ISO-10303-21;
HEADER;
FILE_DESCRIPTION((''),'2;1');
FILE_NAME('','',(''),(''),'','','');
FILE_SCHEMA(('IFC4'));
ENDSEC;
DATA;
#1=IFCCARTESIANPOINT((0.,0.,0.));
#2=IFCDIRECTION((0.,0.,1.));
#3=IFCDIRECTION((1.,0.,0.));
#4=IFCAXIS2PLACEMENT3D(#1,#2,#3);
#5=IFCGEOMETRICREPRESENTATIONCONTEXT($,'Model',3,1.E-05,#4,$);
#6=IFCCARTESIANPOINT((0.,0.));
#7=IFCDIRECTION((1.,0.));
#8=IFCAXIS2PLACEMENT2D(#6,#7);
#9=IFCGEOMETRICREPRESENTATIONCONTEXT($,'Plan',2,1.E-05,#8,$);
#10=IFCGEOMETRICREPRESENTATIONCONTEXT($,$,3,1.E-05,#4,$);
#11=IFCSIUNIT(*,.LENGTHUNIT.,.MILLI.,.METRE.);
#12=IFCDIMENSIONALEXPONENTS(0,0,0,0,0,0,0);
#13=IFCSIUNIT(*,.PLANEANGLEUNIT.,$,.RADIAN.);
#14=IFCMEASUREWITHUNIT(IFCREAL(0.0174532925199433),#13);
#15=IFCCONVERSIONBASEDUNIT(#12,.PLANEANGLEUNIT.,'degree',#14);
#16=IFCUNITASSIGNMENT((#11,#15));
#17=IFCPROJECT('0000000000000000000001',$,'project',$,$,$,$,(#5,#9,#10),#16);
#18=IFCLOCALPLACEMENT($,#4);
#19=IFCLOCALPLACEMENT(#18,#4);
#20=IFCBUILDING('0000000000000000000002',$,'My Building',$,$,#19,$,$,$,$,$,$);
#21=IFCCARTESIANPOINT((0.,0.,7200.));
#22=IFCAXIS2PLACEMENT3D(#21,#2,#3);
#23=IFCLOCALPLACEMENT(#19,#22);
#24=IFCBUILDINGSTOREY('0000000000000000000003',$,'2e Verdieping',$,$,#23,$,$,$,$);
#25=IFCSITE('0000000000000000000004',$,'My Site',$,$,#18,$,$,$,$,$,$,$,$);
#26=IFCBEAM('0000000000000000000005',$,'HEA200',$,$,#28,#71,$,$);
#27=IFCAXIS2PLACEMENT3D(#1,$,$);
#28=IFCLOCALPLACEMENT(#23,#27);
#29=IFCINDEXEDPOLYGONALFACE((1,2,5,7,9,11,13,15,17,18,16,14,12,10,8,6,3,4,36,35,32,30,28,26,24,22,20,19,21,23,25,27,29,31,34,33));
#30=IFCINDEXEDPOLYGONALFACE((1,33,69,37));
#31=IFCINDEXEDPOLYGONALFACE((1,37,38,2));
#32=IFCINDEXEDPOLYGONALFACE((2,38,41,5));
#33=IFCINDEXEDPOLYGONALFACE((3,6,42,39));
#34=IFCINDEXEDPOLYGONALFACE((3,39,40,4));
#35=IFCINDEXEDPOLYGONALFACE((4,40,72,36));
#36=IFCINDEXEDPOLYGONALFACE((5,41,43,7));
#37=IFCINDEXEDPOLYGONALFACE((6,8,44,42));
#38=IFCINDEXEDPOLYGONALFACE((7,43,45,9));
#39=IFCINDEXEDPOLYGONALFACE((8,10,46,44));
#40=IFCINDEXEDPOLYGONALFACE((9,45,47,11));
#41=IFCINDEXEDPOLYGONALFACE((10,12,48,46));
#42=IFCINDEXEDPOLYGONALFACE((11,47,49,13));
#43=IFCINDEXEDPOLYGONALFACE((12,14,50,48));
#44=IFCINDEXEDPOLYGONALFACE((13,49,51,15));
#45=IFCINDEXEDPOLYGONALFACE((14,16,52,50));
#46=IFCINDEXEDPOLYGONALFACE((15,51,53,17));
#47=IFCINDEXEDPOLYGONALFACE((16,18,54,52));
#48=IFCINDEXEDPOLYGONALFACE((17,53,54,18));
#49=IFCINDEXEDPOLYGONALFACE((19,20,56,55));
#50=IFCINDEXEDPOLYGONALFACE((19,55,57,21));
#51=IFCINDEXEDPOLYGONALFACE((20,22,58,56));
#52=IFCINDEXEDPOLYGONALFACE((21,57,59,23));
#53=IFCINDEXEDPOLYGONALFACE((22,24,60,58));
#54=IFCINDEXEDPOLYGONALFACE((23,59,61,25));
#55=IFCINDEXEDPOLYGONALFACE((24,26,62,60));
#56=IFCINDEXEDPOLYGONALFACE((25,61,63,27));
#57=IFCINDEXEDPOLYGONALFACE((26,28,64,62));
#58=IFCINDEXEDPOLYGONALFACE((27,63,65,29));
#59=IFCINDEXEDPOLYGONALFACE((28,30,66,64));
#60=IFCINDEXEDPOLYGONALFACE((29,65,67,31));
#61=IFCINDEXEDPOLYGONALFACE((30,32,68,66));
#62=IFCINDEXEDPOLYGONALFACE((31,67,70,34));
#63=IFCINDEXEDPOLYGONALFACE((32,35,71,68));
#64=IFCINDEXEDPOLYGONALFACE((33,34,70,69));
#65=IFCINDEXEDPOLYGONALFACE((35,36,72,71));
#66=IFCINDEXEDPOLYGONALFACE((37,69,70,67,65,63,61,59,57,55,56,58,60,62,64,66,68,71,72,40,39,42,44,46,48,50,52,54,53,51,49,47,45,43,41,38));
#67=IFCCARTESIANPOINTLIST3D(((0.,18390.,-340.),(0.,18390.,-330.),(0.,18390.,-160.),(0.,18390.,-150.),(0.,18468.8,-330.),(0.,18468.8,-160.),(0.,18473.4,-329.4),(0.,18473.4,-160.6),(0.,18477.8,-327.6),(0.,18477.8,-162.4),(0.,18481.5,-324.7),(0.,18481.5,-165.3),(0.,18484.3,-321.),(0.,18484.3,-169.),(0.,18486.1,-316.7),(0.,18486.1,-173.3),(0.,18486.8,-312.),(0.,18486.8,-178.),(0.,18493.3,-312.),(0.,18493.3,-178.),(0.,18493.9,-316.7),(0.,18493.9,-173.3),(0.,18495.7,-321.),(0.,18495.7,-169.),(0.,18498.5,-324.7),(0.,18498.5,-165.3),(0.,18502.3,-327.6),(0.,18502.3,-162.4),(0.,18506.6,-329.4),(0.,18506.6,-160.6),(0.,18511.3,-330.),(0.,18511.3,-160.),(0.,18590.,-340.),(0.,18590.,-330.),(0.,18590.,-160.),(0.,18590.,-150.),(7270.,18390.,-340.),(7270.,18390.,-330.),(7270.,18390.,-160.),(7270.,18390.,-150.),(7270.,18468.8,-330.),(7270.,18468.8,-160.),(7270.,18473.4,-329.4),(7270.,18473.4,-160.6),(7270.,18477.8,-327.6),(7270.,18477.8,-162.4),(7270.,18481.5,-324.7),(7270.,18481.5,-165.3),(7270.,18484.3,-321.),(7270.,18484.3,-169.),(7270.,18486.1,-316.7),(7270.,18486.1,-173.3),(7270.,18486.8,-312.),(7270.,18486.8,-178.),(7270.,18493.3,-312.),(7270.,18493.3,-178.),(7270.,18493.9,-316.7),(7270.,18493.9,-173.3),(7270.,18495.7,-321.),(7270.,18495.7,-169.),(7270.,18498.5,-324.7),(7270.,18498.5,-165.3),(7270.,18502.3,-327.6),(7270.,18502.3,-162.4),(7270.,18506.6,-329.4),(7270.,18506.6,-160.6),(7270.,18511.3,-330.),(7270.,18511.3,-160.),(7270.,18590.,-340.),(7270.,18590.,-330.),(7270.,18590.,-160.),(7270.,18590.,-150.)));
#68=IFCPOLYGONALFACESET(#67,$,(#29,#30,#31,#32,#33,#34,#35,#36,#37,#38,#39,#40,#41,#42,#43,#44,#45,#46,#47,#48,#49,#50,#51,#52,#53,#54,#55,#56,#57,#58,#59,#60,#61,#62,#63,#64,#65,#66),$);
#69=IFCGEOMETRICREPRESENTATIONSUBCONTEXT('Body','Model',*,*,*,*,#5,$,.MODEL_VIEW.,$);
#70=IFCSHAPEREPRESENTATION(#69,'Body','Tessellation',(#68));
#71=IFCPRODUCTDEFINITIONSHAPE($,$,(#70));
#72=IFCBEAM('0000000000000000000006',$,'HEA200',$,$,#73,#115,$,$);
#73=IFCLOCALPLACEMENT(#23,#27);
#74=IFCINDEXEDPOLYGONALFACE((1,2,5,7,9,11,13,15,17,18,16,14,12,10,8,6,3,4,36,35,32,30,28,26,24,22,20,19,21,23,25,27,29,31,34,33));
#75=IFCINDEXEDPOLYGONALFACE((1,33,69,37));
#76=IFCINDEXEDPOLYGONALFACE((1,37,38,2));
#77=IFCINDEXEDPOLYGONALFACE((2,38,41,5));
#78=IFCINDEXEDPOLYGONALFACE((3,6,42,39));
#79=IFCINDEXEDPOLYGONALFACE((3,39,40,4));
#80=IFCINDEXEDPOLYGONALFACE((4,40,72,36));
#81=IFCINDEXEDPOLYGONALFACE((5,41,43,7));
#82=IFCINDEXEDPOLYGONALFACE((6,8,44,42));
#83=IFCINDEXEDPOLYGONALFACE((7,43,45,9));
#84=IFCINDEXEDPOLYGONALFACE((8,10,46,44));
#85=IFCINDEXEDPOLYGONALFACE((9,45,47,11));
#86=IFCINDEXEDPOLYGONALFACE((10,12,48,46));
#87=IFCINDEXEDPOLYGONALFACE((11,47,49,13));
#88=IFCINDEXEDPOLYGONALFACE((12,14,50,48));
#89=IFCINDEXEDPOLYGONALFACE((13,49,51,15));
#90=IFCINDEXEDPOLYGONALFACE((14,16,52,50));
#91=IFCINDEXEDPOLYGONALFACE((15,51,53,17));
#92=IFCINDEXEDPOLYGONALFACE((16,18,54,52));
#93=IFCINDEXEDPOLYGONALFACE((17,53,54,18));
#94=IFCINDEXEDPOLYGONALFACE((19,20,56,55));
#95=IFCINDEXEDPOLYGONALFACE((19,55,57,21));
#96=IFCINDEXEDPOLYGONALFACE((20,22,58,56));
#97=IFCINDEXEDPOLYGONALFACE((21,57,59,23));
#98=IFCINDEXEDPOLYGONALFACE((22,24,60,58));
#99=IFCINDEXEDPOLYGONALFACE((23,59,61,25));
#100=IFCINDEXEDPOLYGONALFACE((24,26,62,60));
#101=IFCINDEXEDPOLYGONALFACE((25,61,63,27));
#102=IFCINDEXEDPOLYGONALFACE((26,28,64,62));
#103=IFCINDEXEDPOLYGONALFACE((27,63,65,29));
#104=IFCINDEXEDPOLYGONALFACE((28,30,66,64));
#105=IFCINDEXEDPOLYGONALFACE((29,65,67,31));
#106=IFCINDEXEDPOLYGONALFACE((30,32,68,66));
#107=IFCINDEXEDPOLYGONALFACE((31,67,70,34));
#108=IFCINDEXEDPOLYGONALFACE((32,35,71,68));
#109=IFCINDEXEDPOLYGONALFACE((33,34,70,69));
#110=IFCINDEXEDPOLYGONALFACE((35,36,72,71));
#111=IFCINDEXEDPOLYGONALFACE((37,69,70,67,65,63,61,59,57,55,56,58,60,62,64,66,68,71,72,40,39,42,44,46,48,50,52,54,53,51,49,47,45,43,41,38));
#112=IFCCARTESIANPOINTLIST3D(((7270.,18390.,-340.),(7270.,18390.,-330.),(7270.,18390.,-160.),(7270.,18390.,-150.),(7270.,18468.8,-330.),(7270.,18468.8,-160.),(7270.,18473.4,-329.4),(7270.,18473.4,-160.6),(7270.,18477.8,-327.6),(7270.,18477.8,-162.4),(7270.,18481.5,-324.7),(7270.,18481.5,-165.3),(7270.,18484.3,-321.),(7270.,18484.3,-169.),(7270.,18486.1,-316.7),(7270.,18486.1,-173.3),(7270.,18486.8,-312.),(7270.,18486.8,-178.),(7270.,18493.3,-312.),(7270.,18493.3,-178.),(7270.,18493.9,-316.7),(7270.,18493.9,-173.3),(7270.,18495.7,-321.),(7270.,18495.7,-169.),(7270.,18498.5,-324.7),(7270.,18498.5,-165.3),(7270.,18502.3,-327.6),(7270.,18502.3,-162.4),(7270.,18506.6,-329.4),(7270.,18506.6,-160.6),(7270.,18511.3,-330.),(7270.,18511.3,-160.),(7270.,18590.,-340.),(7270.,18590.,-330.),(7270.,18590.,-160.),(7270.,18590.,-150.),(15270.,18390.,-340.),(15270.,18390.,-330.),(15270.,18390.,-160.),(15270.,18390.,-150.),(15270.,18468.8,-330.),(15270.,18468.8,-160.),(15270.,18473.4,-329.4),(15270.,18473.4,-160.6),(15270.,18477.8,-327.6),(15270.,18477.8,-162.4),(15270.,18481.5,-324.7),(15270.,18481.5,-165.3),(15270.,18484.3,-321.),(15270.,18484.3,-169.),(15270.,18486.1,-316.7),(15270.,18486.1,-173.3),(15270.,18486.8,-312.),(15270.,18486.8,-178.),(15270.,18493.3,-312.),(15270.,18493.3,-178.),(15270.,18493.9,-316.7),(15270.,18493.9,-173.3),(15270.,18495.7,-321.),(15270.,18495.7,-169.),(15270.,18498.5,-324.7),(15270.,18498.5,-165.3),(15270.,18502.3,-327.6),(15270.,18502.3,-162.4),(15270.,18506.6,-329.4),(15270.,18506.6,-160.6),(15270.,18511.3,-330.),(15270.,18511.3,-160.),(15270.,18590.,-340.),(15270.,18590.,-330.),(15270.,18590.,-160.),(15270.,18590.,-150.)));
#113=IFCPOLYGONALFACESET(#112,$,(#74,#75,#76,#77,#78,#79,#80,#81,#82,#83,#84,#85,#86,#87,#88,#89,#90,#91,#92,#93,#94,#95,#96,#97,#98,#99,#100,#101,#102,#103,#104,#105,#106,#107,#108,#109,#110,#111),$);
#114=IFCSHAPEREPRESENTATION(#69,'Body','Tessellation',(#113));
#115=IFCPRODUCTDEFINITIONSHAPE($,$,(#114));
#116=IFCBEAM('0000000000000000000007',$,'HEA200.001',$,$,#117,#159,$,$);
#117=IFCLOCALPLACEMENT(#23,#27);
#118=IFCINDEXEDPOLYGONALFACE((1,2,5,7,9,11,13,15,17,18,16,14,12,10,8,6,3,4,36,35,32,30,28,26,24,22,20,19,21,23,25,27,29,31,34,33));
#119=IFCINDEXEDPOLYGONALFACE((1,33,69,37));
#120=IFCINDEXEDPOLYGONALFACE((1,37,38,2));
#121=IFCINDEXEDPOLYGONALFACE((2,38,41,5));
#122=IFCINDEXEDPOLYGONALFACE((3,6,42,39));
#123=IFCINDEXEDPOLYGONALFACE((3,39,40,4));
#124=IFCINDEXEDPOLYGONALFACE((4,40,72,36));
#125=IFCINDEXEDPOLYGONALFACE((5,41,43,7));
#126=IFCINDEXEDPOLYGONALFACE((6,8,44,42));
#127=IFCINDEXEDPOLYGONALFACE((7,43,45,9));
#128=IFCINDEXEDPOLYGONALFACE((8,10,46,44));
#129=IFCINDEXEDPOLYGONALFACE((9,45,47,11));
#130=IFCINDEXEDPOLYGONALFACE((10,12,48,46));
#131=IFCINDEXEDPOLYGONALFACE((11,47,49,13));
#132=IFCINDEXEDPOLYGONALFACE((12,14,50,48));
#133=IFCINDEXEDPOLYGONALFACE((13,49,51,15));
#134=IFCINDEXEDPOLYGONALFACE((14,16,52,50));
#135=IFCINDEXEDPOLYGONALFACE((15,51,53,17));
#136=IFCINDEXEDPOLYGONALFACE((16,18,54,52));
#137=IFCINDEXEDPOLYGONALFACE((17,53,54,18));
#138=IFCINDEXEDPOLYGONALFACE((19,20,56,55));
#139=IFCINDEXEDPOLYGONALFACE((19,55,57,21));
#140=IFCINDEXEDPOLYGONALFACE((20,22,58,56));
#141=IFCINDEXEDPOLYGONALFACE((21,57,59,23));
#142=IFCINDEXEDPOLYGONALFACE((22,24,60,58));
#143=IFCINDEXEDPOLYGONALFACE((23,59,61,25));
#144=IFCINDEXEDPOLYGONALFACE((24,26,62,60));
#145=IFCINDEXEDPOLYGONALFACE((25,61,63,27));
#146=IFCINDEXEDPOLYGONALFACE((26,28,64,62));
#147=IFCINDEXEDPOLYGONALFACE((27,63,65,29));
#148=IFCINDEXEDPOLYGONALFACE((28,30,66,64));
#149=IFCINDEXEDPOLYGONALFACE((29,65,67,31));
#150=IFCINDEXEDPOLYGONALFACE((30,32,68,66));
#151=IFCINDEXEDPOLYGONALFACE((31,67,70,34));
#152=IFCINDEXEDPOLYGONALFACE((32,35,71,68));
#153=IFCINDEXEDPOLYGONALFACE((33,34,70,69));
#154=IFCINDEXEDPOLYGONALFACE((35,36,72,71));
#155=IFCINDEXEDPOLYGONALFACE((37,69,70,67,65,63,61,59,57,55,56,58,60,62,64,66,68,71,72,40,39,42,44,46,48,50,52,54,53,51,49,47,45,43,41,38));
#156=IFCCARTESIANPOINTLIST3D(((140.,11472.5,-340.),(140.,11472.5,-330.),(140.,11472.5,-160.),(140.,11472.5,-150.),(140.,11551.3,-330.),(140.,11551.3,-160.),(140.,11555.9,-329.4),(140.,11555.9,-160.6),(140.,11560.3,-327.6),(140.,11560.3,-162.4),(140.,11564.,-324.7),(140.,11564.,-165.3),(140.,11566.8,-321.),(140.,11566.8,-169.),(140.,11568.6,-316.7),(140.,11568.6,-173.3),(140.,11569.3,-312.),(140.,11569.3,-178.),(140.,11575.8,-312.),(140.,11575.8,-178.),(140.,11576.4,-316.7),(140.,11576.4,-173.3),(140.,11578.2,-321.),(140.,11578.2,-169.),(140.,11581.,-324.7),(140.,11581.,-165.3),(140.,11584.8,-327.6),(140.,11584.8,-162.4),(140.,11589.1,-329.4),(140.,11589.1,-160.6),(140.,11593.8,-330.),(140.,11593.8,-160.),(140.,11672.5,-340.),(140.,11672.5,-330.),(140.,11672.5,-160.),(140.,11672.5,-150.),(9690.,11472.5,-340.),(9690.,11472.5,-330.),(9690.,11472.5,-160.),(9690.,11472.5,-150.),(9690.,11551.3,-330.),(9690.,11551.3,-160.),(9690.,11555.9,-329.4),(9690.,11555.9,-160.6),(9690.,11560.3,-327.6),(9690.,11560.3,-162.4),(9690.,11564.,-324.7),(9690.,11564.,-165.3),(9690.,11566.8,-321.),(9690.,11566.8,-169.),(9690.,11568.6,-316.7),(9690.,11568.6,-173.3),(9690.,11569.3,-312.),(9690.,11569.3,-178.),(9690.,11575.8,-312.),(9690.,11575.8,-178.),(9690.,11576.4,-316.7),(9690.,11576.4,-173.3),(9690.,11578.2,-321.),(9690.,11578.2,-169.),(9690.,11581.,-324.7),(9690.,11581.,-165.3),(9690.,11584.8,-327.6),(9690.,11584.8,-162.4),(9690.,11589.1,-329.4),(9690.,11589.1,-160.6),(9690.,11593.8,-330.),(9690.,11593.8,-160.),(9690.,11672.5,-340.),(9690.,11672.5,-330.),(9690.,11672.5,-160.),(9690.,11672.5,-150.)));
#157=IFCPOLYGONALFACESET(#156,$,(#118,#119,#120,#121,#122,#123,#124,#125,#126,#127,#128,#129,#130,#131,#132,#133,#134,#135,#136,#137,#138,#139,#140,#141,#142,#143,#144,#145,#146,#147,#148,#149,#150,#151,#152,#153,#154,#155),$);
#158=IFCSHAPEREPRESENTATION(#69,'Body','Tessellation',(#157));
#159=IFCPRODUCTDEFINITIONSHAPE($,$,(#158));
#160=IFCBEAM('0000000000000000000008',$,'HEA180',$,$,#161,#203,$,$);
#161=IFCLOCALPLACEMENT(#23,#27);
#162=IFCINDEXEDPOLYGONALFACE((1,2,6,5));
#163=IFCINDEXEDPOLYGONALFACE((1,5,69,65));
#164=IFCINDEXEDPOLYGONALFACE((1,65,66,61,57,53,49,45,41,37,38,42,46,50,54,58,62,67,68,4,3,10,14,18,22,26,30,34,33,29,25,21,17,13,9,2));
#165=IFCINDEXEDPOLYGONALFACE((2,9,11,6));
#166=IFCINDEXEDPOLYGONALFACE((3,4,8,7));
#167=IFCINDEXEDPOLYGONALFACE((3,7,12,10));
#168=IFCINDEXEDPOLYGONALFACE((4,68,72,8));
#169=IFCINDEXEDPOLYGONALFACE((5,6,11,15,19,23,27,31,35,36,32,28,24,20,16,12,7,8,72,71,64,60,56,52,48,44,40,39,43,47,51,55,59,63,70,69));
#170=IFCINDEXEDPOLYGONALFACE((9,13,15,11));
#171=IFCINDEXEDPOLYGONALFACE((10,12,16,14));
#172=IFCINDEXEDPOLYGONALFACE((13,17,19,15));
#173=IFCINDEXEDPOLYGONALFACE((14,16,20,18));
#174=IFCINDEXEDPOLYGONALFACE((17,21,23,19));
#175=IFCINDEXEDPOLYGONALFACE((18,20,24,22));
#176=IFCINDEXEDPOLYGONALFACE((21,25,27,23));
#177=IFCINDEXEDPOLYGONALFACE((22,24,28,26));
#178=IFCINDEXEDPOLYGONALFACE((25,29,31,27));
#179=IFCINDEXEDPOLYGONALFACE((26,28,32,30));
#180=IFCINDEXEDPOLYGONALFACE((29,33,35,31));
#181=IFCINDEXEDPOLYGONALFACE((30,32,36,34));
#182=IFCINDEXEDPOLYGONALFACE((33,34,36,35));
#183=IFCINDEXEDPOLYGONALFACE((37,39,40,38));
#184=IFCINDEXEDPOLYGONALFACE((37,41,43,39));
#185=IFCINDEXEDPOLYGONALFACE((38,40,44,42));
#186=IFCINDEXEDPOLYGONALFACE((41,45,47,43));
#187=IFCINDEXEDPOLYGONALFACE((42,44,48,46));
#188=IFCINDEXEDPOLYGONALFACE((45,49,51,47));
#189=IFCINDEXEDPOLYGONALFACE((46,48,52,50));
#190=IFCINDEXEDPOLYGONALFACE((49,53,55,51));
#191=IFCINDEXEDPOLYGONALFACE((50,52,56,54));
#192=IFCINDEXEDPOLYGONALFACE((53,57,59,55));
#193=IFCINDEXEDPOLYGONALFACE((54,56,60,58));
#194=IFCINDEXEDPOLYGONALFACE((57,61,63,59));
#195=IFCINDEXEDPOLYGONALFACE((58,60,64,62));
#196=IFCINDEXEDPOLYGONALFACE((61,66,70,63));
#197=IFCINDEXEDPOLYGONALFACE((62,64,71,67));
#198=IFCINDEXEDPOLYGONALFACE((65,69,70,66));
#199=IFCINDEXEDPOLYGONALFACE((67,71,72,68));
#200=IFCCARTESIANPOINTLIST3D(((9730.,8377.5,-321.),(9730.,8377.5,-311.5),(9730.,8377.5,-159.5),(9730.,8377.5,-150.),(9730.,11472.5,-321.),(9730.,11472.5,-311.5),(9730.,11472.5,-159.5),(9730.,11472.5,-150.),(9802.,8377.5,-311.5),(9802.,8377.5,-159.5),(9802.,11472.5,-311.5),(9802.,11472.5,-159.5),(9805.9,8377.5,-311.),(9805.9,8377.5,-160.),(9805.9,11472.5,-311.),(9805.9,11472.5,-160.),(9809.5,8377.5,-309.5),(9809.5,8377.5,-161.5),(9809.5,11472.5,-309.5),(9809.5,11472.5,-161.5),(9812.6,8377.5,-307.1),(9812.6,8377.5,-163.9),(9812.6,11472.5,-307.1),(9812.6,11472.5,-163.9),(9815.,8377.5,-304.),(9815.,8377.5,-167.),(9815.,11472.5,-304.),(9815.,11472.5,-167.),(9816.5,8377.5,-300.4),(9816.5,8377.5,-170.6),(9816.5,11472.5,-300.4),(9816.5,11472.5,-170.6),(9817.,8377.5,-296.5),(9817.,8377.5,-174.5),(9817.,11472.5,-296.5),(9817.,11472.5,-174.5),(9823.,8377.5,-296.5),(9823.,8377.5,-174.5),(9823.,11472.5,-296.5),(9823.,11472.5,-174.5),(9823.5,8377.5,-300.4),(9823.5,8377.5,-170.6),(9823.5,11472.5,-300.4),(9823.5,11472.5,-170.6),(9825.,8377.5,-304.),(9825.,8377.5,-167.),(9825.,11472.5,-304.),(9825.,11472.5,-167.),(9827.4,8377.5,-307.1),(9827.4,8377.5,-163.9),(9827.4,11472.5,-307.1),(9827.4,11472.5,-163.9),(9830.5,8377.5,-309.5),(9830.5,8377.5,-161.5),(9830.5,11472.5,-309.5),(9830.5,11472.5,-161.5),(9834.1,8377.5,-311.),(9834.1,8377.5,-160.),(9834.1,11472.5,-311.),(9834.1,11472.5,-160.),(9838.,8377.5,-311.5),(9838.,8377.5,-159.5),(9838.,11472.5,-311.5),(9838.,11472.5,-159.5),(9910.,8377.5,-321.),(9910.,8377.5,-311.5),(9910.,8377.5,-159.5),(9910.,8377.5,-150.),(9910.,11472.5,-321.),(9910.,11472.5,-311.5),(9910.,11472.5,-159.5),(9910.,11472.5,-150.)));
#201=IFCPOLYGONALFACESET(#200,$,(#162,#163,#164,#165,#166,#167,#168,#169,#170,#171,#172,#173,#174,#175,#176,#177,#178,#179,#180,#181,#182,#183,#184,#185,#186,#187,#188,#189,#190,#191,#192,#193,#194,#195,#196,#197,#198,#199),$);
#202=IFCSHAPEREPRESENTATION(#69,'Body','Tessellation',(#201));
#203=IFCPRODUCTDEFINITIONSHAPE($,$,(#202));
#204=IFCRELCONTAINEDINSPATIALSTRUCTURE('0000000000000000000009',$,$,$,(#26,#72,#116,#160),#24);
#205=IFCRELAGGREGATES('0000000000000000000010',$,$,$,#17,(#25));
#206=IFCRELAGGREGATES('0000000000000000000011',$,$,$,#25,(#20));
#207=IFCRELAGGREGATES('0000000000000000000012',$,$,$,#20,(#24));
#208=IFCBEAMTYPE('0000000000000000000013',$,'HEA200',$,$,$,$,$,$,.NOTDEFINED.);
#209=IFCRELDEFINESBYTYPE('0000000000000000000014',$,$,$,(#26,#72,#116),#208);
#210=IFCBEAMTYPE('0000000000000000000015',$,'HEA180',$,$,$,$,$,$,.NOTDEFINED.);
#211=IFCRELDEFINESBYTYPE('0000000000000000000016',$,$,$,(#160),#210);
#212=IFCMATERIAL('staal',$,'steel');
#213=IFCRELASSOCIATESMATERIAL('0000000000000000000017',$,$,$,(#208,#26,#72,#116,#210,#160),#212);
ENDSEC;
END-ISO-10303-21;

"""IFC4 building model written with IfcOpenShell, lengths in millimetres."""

from ifc_helpers import new_model, entity, si_unit, converted_unit, frame, origin_with_axes, origin_2d_with_axis, place, context, subcontext, project, spatial, i_section, extrude, material, material_profile, profile_set, profile_usage, type_object, element, save


model = new_model("IFC4")

# Units and contexts
model_context = context("Model", 3, precision=1e-05, world=origin_with_axes())
plan_context = context("Plan", 2, precision=1e-05, world=origin_2d_with_axis())
context_of_model = context(None, 3, precision=1e-05, world=origin_with_axes())
body_context = subcontext(model_context, "Body", "Model", "MODEL_VIEW")
ifc_project = project(units=[si_unit("LENGTHUNIT", "METRE", prefix="MILLI"), converted_unit("PLANEANGLEUNIT", "degree", entity("IfcReal", 0.0174532925199433), si_unit("PLANEANGLEUNIT", "RADIAN"), dimensions=[0, 0, 0, 0, 0, 0, 0])], contexts=[model_context, plan_context, context_of_model])

# Site, building, storey
site_placement = place(None, origin_with_axes())
site = spatial("IfcSite", under=ifc_project, at=site_placement, Name="My Site")
building_placement = place(site_placement, origin_with_axes())
building = spatial("IfcBuilding", under=site, at=building_placement, Name="My Building")
storey_placement = place(building_placement, frame((0.0, 0.0, 7200.0), z_axis=(0.0, 0.0, 1.0), x_axis=(1.0, 0.0, 0.0)))
storey = spatial("IfcBuildingStorey", under=building, at=storey_placement, Name="2e Verdieping")

# Beams
ifc_material_1 = material(Name="staal", Category="steel")
ifc_material_profile_1 = material_profile(ifc_material_1, i_section(OverallWidth=200.0, OverallDepth=190.0, WebThickness=6.5, FlangeThickness=10.0, FilletRadius=18.0))
ifc_profile_set_1 = profile_set([ifc_material_profile_1], Name="HEA200")
ifc_profile_usage_1 = profile_usage(ifc_profile_set_1, cardinal=5)
beam_type_1 = type_object("IfcBeamType", Name="HEA200", PredefinedType="NOTDEFINED", material=ifc_profile_set_1)
beam_1_placement = place(storey_placement, frame((0.0, 18490.0, -245.0), z_axis=(1.0, 0.0, 0.0), x_axis=(0.0, 1.0, 0.0)))
element("IfcBeam", 1, at=beam_1_placement, inside=storey, type_object=beam_type_1, material=ifc_profile_usage_1, Name="HEA200", context=body_context, shape_type="SweptSolid", body=[
    extrude(i_section(OverallWidth=200.0, OverallDepth=190.0, WebThickness=6.5, FlangeThickness=10.0, FilletRadius=18.0), origin_with_axes(), (0.0, 0.0, 1.0), 7270.0),
])
ifc_profile_usage_2 = profile_usage(ifc_profile_set_1, cardinal=5)
beam_2_placement = place(storey_placement, frame((7270.0, 18490.0, -245.0), z_axis=(1.0, 0.0, 0.0), x_axis=(0.0, 1.0, 0.0)))
element("IfcBeam", 2, at=beam_2_placement, inside=storey, type_object=beam_type_1, material=ifc_profile_usage_2, Name="HEA200", context=body_context, shape_type="SweptSolid", body=[
    extrude(i_section(OverallWidth=200.0, OverallDepth=190.0, WebThickness=6.5, FlangeThickness=10.0, FilletRadius=18.0), origin_with_axes(), (0.0, 0.0, 1.0), 8000.0),
])
ifc_profile_usage_3 = profile_usage(ifc_profile_set_1)
beam_3_placement = place(storey_placement, frame((140.0, 11572.5, -245.0), z_axis=(1.0, 0.0, 0.0), x_axis=(0.0, 1.0, 0.0)))
element("IfcBeam", 3, at=beam_3_placement, inside=storey, type_object=beam_type_1, material=ifc_profile_usage_3, Name="HEA200.001", context=body_context, shape_type="SweptSolid", body=[
    extrude(i_section(OverallWidth=200.0, OverallDepth=190.0, WebThickness=6.5, FlangeThickness=10.0, FilletRadius=18.0), origin_with_axes(), (0.0, 0.0, 1.0), 9550.0),
])
ifc_material_profile_2 = material_profile(ifc_material_1, i_section(OverallWidth=180.0, OverallDepth=171.0, WebThickness=6.0, FlangeThickness=9.5, FilletRadius=15.0))
ifc_profile_set_2 = profile_set([ifc_material_profile_2], Name="HEA180")
ifc_profile_usage_4 = profile_usage(ifc_profile_set_2)
beam_type_2 = type_object("IfcBeamType", Name="HEA180", PredefinedType="NOTDEFINED", material=ifc_profile_set_2)
beam_4_placement = place(storey_placement, frame((9820.0, 11472.5, -235.5), z_axis=(0.0, -1.0, 0.0), x_axis=(1.0, 0.0, 0.0)))
element("IfcBeam", 4, at=beam_4_placement, inside=storey, type_object=beam_type_2, material=ifc_profile_usage_4, Name="HEA180", context=body_context, shape_type="SweptSolid", body=[
    extrude(i_section(OverallWidth=180.0, OverallDepth=171.0, WebThickness=6.0, FlangeThickness=9.5, FilletRadius=15.0), origin_with_axes(), (0.0, 0.0, 1.0), 3095.0),
])

save(model, "model.ifc")
